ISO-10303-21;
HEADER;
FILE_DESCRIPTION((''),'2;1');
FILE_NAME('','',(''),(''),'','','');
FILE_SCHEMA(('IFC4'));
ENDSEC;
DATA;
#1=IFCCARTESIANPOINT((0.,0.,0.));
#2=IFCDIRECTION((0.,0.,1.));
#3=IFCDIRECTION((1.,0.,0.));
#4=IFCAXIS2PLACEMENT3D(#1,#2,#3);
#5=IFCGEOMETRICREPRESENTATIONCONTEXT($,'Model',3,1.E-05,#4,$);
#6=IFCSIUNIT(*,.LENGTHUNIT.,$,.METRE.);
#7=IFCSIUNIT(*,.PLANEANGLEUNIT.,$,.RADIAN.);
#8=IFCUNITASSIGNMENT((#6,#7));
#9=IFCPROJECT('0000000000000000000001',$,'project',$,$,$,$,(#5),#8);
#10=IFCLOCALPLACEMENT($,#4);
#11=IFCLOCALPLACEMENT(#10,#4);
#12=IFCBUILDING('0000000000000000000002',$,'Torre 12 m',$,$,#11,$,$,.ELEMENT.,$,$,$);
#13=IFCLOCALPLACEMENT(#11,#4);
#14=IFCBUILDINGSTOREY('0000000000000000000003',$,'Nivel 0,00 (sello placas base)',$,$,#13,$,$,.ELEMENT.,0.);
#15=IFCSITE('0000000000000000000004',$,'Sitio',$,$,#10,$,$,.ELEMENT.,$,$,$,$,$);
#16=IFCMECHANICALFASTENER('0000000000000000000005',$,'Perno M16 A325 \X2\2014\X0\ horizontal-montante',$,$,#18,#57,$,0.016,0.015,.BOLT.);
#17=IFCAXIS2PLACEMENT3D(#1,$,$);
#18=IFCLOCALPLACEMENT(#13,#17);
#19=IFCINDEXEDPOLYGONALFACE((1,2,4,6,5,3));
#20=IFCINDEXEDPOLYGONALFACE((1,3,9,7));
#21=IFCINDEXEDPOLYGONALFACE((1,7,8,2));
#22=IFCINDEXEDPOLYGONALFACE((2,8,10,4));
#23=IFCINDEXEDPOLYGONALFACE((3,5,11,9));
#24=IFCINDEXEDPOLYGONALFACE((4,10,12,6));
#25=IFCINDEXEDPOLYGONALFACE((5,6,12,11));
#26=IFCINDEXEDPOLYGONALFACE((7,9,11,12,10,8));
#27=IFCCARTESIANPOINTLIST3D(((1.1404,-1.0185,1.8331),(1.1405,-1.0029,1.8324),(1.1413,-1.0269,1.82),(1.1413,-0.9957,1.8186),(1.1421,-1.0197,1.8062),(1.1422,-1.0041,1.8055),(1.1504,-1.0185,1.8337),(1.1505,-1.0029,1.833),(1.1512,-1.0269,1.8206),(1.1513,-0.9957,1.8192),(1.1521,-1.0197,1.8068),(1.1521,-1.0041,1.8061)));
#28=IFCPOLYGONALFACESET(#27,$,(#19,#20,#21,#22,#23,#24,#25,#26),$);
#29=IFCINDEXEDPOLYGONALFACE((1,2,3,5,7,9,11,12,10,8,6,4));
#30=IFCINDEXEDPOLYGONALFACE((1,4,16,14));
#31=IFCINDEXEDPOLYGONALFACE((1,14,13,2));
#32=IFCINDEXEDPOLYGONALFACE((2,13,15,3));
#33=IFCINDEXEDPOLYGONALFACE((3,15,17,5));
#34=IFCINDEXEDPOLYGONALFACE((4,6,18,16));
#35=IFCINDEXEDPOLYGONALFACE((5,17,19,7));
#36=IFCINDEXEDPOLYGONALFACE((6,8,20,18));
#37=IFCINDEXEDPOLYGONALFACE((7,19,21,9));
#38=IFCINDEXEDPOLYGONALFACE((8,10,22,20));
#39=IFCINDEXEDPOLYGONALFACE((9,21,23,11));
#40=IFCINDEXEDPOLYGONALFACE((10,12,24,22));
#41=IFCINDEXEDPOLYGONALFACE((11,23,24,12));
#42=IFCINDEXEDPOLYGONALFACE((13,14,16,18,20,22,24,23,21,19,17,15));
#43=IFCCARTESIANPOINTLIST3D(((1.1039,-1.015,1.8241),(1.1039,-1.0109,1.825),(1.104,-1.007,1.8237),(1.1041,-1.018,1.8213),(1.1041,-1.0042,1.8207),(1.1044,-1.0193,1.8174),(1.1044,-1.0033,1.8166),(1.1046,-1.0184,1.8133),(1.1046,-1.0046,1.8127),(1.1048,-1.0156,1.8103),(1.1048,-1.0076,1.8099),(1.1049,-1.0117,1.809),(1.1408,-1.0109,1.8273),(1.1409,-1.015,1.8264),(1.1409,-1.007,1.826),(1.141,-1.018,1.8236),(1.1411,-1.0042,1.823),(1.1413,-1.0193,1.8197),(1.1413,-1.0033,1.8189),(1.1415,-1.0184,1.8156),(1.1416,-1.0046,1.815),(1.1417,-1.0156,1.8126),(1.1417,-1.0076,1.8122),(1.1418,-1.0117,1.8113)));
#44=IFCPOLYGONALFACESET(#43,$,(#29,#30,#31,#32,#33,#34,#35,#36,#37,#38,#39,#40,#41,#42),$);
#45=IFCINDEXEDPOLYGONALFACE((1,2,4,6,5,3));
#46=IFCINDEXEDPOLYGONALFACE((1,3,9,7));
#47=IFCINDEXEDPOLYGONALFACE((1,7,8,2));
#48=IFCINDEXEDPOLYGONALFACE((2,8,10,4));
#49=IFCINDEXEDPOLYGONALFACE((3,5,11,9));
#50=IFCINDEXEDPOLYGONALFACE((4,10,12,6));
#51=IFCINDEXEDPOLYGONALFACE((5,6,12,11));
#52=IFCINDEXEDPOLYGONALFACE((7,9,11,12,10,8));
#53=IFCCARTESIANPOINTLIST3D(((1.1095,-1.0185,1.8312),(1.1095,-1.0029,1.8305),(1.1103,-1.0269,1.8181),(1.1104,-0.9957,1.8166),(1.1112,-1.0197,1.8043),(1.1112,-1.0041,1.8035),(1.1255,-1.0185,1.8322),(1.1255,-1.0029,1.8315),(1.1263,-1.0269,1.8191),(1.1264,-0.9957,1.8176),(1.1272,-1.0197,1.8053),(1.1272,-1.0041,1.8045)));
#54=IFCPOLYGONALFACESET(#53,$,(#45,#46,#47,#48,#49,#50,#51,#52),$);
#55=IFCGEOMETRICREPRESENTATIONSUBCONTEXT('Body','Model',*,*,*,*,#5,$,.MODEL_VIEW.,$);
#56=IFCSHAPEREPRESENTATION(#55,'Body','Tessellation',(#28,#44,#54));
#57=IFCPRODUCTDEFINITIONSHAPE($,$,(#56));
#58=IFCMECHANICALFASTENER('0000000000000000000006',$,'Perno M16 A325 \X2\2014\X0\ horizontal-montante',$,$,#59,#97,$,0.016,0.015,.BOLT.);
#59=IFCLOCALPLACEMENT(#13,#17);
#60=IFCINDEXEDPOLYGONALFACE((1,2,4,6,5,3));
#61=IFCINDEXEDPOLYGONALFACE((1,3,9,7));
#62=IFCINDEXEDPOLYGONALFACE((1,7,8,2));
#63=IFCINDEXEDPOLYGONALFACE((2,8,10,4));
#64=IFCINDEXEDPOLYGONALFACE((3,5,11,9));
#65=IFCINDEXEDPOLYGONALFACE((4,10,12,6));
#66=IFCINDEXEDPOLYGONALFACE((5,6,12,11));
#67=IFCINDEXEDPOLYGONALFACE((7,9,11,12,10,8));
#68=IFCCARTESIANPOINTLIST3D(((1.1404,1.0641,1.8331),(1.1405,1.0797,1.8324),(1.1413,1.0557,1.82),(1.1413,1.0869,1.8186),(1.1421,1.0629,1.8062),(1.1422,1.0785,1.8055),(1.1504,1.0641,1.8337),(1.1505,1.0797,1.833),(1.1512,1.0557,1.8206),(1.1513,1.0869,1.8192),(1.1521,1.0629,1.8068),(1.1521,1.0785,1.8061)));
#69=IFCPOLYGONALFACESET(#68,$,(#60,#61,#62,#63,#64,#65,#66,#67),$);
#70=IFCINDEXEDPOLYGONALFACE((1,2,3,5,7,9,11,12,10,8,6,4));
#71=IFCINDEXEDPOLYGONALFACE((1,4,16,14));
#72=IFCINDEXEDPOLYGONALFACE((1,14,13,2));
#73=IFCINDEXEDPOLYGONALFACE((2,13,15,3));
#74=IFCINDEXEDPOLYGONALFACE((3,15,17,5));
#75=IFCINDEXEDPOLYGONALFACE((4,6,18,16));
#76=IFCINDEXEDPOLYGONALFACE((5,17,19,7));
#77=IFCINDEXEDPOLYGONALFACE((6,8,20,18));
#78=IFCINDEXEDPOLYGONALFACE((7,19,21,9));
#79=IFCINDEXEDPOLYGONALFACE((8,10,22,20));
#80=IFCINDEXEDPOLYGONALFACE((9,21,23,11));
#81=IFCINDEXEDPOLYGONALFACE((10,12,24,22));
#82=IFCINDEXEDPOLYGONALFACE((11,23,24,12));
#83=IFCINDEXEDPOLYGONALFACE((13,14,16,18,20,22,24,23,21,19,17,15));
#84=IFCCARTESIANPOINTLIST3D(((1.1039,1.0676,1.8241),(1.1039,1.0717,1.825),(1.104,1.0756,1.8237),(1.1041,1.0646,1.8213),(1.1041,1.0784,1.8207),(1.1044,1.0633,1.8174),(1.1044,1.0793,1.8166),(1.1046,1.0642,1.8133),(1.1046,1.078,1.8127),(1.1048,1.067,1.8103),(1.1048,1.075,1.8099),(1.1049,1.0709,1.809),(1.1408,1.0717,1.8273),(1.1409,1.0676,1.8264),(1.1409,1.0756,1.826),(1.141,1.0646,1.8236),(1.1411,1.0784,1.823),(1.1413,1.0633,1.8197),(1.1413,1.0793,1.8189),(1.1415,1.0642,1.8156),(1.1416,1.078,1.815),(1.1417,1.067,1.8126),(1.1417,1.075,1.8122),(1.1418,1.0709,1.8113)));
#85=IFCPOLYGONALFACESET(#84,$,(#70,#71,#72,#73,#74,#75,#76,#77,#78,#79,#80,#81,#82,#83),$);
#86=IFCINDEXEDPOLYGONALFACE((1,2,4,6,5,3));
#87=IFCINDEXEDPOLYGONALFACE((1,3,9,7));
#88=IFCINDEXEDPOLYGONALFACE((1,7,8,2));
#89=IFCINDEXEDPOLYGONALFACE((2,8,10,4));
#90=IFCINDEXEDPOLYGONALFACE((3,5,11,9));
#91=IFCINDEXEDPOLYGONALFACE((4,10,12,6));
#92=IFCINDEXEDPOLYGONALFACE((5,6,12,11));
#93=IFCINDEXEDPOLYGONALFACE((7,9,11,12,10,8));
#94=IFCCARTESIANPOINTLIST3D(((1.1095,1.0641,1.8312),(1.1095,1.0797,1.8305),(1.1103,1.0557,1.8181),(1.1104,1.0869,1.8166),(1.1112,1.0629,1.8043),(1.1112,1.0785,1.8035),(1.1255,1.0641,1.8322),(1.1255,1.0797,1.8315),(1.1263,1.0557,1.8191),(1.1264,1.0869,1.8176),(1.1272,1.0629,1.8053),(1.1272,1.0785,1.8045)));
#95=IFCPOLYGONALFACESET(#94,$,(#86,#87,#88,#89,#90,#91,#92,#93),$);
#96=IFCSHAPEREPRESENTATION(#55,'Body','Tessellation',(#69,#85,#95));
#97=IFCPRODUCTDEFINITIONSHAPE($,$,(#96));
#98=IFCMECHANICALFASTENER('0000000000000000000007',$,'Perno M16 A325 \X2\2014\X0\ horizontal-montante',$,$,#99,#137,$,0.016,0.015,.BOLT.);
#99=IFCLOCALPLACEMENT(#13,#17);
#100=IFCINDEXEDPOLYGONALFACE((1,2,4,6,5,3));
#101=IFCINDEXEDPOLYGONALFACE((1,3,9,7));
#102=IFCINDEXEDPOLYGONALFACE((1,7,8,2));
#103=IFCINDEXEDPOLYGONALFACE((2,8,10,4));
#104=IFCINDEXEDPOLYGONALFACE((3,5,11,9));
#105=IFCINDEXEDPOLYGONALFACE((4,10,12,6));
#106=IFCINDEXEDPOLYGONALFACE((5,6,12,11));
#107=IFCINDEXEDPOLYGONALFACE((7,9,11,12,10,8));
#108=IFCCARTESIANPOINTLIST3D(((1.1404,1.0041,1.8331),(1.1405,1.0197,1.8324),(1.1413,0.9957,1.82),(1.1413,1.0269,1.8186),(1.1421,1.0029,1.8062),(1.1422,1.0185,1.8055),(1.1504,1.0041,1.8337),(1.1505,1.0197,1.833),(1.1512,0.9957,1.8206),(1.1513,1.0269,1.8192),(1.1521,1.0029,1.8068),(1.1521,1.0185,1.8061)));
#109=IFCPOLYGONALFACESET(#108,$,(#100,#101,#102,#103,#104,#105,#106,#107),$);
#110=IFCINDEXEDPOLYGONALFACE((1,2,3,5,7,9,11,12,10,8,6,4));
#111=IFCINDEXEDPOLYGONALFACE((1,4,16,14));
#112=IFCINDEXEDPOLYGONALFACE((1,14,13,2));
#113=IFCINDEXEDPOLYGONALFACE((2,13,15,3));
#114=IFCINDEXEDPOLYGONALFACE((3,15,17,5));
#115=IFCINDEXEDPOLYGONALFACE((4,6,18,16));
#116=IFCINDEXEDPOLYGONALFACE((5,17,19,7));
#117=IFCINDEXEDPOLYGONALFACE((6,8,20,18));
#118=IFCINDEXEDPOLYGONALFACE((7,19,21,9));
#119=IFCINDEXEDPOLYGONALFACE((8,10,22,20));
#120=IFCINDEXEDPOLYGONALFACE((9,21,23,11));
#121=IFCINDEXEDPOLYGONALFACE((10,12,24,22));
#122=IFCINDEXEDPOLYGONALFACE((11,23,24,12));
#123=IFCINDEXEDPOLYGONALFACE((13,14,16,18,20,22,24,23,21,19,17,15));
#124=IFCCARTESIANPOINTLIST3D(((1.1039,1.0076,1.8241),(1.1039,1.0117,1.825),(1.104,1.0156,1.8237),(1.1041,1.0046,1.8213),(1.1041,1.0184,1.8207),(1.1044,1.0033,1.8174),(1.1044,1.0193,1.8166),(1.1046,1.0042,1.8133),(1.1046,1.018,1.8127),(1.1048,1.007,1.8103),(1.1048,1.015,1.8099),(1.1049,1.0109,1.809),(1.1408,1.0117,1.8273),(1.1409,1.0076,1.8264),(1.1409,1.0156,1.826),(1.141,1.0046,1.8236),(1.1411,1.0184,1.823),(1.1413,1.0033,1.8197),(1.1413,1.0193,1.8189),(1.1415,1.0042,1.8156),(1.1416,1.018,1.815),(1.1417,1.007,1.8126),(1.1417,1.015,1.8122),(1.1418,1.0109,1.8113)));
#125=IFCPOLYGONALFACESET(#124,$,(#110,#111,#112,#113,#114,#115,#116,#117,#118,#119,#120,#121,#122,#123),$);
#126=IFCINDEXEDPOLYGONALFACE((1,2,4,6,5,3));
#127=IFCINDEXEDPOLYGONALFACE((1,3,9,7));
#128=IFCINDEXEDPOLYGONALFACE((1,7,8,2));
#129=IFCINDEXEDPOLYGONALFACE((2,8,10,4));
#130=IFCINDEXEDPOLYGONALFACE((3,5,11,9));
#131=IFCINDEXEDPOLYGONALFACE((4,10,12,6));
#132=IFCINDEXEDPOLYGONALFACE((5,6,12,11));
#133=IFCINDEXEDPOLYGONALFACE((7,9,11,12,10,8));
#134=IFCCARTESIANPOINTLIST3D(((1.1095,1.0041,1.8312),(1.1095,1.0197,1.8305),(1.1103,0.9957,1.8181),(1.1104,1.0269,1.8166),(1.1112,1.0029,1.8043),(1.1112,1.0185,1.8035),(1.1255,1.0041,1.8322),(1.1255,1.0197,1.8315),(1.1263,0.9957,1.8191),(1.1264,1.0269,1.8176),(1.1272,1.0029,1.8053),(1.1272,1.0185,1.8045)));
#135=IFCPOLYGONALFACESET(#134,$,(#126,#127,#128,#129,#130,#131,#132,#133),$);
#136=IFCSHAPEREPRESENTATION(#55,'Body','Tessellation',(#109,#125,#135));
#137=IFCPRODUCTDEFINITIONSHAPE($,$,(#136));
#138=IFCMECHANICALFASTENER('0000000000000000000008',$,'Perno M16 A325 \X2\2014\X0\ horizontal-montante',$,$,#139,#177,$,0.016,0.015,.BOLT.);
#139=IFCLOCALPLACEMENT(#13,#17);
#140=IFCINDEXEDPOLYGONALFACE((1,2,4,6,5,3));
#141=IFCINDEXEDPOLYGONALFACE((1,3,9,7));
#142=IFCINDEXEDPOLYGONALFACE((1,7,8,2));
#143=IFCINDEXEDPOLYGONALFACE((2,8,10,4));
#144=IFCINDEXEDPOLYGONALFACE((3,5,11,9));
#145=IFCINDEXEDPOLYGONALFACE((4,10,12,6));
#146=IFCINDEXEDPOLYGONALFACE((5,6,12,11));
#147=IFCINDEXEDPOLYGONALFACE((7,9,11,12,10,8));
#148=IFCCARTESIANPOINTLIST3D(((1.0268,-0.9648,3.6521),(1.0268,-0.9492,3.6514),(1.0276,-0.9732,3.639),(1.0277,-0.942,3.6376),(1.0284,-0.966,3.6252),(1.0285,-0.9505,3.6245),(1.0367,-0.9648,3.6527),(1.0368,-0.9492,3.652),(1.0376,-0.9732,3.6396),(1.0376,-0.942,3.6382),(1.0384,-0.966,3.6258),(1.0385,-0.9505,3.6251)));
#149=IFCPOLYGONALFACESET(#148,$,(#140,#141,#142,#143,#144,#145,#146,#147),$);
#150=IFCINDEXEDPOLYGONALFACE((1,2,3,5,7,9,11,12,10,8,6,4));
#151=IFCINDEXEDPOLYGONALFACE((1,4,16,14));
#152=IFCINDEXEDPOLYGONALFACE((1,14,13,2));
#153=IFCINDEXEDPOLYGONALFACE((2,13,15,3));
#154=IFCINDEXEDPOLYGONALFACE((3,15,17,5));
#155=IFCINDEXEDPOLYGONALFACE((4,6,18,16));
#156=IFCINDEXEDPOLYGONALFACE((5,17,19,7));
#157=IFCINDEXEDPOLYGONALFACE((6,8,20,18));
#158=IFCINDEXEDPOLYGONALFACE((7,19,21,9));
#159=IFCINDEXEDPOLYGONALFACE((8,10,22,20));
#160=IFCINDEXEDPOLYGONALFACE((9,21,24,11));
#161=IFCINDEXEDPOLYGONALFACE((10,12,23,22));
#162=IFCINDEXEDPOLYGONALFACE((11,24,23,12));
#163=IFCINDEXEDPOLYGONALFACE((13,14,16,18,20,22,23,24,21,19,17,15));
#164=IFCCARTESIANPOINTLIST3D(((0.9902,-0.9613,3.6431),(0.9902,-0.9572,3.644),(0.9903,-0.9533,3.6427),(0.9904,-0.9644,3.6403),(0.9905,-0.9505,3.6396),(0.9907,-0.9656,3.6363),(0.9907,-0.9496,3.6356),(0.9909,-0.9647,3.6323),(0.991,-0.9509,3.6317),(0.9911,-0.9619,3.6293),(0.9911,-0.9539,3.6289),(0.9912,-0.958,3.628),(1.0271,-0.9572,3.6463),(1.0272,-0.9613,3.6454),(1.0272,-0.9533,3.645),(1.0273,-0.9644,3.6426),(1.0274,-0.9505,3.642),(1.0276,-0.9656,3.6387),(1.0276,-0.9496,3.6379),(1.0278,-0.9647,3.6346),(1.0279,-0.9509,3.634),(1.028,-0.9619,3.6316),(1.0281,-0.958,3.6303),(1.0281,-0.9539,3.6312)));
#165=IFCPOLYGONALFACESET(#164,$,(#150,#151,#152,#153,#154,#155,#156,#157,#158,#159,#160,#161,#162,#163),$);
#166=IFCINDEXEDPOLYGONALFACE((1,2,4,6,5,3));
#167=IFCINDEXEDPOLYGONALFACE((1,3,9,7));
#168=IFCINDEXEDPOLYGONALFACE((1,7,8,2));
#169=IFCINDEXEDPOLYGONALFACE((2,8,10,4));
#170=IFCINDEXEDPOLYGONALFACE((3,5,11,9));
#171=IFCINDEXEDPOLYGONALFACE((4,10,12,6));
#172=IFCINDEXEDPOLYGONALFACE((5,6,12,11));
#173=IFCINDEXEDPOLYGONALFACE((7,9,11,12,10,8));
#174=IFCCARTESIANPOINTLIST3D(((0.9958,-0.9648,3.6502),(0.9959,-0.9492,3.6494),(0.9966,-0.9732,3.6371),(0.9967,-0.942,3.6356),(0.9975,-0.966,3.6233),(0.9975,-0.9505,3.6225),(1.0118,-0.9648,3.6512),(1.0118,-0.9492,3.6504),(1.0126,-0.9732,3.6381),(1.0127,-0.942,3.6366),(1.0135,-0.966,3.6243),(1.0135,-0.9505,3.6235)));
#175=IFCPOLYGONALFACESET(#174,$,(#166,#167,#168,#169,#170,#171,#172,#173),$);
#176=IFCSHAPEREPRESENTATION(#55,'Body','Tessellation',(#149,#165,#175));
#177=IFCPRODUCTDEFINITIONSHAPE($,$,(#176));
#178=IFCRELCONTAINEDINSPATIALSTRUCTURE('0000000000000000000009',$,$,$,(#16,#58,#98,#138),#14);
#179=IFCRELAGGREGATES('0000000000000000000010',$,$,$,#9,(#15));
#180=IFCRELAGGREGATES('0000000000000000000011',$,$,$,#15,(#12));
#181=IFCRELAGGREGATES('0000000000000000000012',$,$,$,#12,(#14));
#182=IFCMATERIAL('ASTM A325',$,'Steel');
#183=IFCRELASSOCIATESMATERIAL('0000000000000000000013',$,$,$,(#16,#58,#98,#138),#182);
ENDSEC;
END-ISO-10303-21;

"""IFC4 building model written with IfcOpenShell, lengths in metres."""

from ifc_helpers import new_model, si_unit, frame, origin_with_axes, place, context, subcontext, project, spatial, polyline, outline, extrude, material, element, save


model = new_model("IFC4")

# Units and contexts
model_context = context("Model", 3, precision=1e-05, world=origin_with_axes())
body_context = subcontext(model_context, "Body", "Model", "MODEL_VIEW")
ifc_project = project(units=[si_unit("LENGTHUNIT", "METRE"), si_unit("PLANEANGLEUNIT", "RADIAN")], contexts=[model_context])

# Site, building, storey
site_placement = place(None, origin_with_axes())
site = spatial("IfcSite", under=ifc_project, at=site_placement, Name="Sitio", CompositionType="ELEMENT")
building_placement = place(site_placement, origin_with_axes())
building = spatial("IfcBuilding", under=site, at=building_placement, Name="Torre 12 m", CompositionType="ELEMENT")
storey_placement = place(building_placement, origin_with_axes())
storey = spatial("IfcBuildingStorey", under=building, at=storey_placement, Name="Nivel 0,00 (sello placas base)", CompositionType="ELEMENT", Elevation=0.0)

# Shared definitions
placement = place(storey_placement, origin_with_axes())

# Mechanical fasteners
ifc_material_1 = material(Name="ASTM A325", Category="Steel")
element("IfcMechanicalFastener", 1, at=placement, inside=storey, material=ifc_material_1, Name="Perno M16 A325 — horizontal-montante", NominalDiameter=0.016, NominalLength=0.015, PredefinedType="BOLT", context=body_context, shape_type="SweptSolid", body=[
    extrude(outline(polyline([(0.0135, 0.0078), (0.0, 0.0156), (-0.0135, 0.0078), (-0.0135, -0.0078), (0.0, -0.0156), (0.0135, -0.0078), (0.0135, 0.0078)])), frame((1.1513, -1.0113, 1.8199), z_axis=(-0.998053, 0.0, -0.062378), x_axis=(0.033672, 0.841794, -0.538748)), (0.0, 0.0, 1.0), 0.01),
    extrude(outline(polyline([(0.008, 0.0), (0.0069, 0.004), (0.004, 0.0069), (0.0, 0.008), (-0.004, 0.0069), (-0.0069, 0.004), (-0.008, 0.0), (-0.0069, -0.004), (-0.004, -0.0069), (0.0, -0.008), (0.004, -0.0069), (0.0069, -0.004), (0.008, 0.0)])), frame((1.1413, -1.0113, 1.8193), z_axis=(-0.998053, 0.0, -0.062378), x_axis=(0.033672, 0.841794, -0.538748)), (0.0, 0.0, 1.0), 0.037),
    extrude(outline(polyline([(0.0135, 0.0078), (0.0, 0.0156), (-0.0135, 0.0078), (-0.0135, -0.0078), (0.0, -0.0156), (0.0135, -0.0078), (0.0135, 0.0078)])), frame((1.1263, -1.0113, 1.8184), z_axis=(-0.998053, 0.0, -0.062378), x_axis=(0.033672, 0.841794, -0.538748)), (0.0, 0.0, 1.0), 0.016),
])
element("IfcMechanicalFastener", 2, at=placement, inside=storey, material=ifc_material_1, Name="Perno M16 A325 — horizontal-montante", NominalDiameter=0.016, NominalLength=0.015, PredefinedType="BOLT", context=body_context, shape_type="SweptSolid", body=[
    extrude(outline(polyline([(0.0135, 0.0078), (0.0, 0.0156), (-0.0135, 0.0078), (-0.0135, -0.0078), (0.0, -0.0156), (0.0135, -0.0078), (0.0135, 0.0078)])), frame((1.1513, 1.0713, 1.8199), z_axis=(-0.998053, 0.0, -0.062378), x_axis=(0.033672, 0.841794, -0.538748)), (0.0, 0.0, 1.0), 0.01),
    extrude(outline(polyline([(0.008, 0.0), (0.0069, 0.004), (0.004, 0.0069), (0.0, 0.008), (-0.004, 0.0069), (-0.0069, 0.004), (-0.008, 0.0), (-0.0069, -0.004), (-0.004, -0.0069), (0.0, -0.008), (0.004, -0.0069), (0.0069, -0.004), (0.008, 0.0)])), frame((1.1413, 1.0713, 1.8193), z_axis=(-0.998053, 0.0, -0.062378), x_axis=(0.033672, 0.841794, -0.538748)), (0.0, 0.0, 1.0), 0.037),
    extrude(outline(polyline([(0.0135, 0.0078), (0.0, 0.0156), (-0.0135, 0.0078), (-0.0135, -0.0078), (0.0, -0.0156), (0.0135, -0.0078), (0.0135, 0.0078)])), frame((1.1263, 1.0713, 1.8184), z_axis=(-0.998053, 0.0, -0.062378), x_axis=(0.033672, 0.841794, -0.538748)), (0.0, 0.0, 1.0), 0.016),
])
element("IfcMechanicalFastener", 3, at=placement, inside=storey, material=ifc_material_1, Name="Perno M16 A325 — horizontal-montante", NominalDiameter=0.016, NominalLength=0.015, PredefinedType="BOLT", context=body_context, shape_type="SweptSolid", body=[
    extrude(outline(polyline([(0.0135, 0.0078), (0.0, 0.0156), (-0.0135, 0.0078), (-0.0135, -0.0078), (0.0, -0.0156), (0.0135, -0.0078), (0.0135, 0.0078)])), frame((1.1513, 1.0113, 1.8199), z_axis=(-0.998053, 0.0, -0.062378), x_axis=(0.033672, 0.841794, -0.538748)), (0.0, 0.0, 1.0), 0.01),
    extrude(outline(polyline([(0.008, 0.0), (0.0069, 0.004), (0.004, 0.0069), (0.0, 0.008), (-0.004, 0.0069), (-0.0069, 0.004), (-0.008, 0.0), (-0.0069, -0.004), (-0.004, -0.0069), (0.0, -0.008), (0.004, -0.0069), (0.0069, -0.004), (0.008, 0.0)])), frame((1.1413, 1.0113, 1.8193), z_axis=(-0.998053, 0.0, -0.062378), x_axis=(0.033672, 0.841794, -0.538748)), (0.0, 0.0, 1.0), 0.037),
    extrude(outline(polyline([(0.0135, 0.0078), (0.0, 0.0156), (-0.0135, 0.0078), (-0.0135, -0.0078), (0.0, -0.0156), (0.0135, -0.0078), (0.0135, 0.0078)])), frame((1.1263, 1.0113, 1.8184), z_axis=(-0.998053, 0.0, -0.062378), x_axis=(0.033672, 0.841794, -0.538748)), (0.0, 0.0, 1.0), 0.016),
])
element("IfcMechanicalFastener", 4, at=placement, inside=storey, material=ifc_material_1, Name="Perno M16 A325 — horizontal-montante", NominalDiameter=0.016, NominalLength=0.015, PredefinedType="BOLT", context=body_context, shape_type="SweptSolid", body=[
    extrude(outline(polyline([(0.0135, 0.0078), (0.0, 0.0156), (-0.0135, 0.0078), (-0.0135, -0.0078), (0.0, -0.0156), (0.0135, -0.0078), (0.0135, 0.0078)])), frame((1.0376, -0.9576, 3.6389), z_axis=(-0.998053, 0.0, -0.062378), x_axis=(0.033672, 0.841794, -0.538748)), (0.0, 0.0, 1.0), 0.01),
    extrude(outline(polyline([(0.008, 0.0), (0.0069, 0.004), (0.004, 0.0069), (0.0, 0.008), (-0.004, 0.0069), (-0.0069, 0.004), (-0.008, 0.0), (-0.0069, -0.004), (-0.004, -0.0069), (0.0, -0.008), (0.004, -0.0069), (0.0069, -0.004), (0.008, 0.0)])), frame((1.0276, -0.9576, 3.6383), z_axis=(-0.998053, 0.0, -0.062378), x_axis=(0.033672, 0.841794, -0.538748)), (0.0, 0.0, 1.0), 0.037),
    extrude(outline(polyline([(0.0135, 0.0078), (0.0, 0.0156), (-0.0135, 0.0078), (-0.0135, -0.0078), (0.0, -0.0156), (0.0135, -0.0078), (0.0135, 0.0078)])), frame((1.0126, -0.9576, 3.6374), z_axis=(-0.998053, 0.0, -0.062378), x_axis=(0.033672, 0.841794, -0.538748)), (0.0, 0.0, 1.0), 0.016),
])

save(model, "model.ifc")
